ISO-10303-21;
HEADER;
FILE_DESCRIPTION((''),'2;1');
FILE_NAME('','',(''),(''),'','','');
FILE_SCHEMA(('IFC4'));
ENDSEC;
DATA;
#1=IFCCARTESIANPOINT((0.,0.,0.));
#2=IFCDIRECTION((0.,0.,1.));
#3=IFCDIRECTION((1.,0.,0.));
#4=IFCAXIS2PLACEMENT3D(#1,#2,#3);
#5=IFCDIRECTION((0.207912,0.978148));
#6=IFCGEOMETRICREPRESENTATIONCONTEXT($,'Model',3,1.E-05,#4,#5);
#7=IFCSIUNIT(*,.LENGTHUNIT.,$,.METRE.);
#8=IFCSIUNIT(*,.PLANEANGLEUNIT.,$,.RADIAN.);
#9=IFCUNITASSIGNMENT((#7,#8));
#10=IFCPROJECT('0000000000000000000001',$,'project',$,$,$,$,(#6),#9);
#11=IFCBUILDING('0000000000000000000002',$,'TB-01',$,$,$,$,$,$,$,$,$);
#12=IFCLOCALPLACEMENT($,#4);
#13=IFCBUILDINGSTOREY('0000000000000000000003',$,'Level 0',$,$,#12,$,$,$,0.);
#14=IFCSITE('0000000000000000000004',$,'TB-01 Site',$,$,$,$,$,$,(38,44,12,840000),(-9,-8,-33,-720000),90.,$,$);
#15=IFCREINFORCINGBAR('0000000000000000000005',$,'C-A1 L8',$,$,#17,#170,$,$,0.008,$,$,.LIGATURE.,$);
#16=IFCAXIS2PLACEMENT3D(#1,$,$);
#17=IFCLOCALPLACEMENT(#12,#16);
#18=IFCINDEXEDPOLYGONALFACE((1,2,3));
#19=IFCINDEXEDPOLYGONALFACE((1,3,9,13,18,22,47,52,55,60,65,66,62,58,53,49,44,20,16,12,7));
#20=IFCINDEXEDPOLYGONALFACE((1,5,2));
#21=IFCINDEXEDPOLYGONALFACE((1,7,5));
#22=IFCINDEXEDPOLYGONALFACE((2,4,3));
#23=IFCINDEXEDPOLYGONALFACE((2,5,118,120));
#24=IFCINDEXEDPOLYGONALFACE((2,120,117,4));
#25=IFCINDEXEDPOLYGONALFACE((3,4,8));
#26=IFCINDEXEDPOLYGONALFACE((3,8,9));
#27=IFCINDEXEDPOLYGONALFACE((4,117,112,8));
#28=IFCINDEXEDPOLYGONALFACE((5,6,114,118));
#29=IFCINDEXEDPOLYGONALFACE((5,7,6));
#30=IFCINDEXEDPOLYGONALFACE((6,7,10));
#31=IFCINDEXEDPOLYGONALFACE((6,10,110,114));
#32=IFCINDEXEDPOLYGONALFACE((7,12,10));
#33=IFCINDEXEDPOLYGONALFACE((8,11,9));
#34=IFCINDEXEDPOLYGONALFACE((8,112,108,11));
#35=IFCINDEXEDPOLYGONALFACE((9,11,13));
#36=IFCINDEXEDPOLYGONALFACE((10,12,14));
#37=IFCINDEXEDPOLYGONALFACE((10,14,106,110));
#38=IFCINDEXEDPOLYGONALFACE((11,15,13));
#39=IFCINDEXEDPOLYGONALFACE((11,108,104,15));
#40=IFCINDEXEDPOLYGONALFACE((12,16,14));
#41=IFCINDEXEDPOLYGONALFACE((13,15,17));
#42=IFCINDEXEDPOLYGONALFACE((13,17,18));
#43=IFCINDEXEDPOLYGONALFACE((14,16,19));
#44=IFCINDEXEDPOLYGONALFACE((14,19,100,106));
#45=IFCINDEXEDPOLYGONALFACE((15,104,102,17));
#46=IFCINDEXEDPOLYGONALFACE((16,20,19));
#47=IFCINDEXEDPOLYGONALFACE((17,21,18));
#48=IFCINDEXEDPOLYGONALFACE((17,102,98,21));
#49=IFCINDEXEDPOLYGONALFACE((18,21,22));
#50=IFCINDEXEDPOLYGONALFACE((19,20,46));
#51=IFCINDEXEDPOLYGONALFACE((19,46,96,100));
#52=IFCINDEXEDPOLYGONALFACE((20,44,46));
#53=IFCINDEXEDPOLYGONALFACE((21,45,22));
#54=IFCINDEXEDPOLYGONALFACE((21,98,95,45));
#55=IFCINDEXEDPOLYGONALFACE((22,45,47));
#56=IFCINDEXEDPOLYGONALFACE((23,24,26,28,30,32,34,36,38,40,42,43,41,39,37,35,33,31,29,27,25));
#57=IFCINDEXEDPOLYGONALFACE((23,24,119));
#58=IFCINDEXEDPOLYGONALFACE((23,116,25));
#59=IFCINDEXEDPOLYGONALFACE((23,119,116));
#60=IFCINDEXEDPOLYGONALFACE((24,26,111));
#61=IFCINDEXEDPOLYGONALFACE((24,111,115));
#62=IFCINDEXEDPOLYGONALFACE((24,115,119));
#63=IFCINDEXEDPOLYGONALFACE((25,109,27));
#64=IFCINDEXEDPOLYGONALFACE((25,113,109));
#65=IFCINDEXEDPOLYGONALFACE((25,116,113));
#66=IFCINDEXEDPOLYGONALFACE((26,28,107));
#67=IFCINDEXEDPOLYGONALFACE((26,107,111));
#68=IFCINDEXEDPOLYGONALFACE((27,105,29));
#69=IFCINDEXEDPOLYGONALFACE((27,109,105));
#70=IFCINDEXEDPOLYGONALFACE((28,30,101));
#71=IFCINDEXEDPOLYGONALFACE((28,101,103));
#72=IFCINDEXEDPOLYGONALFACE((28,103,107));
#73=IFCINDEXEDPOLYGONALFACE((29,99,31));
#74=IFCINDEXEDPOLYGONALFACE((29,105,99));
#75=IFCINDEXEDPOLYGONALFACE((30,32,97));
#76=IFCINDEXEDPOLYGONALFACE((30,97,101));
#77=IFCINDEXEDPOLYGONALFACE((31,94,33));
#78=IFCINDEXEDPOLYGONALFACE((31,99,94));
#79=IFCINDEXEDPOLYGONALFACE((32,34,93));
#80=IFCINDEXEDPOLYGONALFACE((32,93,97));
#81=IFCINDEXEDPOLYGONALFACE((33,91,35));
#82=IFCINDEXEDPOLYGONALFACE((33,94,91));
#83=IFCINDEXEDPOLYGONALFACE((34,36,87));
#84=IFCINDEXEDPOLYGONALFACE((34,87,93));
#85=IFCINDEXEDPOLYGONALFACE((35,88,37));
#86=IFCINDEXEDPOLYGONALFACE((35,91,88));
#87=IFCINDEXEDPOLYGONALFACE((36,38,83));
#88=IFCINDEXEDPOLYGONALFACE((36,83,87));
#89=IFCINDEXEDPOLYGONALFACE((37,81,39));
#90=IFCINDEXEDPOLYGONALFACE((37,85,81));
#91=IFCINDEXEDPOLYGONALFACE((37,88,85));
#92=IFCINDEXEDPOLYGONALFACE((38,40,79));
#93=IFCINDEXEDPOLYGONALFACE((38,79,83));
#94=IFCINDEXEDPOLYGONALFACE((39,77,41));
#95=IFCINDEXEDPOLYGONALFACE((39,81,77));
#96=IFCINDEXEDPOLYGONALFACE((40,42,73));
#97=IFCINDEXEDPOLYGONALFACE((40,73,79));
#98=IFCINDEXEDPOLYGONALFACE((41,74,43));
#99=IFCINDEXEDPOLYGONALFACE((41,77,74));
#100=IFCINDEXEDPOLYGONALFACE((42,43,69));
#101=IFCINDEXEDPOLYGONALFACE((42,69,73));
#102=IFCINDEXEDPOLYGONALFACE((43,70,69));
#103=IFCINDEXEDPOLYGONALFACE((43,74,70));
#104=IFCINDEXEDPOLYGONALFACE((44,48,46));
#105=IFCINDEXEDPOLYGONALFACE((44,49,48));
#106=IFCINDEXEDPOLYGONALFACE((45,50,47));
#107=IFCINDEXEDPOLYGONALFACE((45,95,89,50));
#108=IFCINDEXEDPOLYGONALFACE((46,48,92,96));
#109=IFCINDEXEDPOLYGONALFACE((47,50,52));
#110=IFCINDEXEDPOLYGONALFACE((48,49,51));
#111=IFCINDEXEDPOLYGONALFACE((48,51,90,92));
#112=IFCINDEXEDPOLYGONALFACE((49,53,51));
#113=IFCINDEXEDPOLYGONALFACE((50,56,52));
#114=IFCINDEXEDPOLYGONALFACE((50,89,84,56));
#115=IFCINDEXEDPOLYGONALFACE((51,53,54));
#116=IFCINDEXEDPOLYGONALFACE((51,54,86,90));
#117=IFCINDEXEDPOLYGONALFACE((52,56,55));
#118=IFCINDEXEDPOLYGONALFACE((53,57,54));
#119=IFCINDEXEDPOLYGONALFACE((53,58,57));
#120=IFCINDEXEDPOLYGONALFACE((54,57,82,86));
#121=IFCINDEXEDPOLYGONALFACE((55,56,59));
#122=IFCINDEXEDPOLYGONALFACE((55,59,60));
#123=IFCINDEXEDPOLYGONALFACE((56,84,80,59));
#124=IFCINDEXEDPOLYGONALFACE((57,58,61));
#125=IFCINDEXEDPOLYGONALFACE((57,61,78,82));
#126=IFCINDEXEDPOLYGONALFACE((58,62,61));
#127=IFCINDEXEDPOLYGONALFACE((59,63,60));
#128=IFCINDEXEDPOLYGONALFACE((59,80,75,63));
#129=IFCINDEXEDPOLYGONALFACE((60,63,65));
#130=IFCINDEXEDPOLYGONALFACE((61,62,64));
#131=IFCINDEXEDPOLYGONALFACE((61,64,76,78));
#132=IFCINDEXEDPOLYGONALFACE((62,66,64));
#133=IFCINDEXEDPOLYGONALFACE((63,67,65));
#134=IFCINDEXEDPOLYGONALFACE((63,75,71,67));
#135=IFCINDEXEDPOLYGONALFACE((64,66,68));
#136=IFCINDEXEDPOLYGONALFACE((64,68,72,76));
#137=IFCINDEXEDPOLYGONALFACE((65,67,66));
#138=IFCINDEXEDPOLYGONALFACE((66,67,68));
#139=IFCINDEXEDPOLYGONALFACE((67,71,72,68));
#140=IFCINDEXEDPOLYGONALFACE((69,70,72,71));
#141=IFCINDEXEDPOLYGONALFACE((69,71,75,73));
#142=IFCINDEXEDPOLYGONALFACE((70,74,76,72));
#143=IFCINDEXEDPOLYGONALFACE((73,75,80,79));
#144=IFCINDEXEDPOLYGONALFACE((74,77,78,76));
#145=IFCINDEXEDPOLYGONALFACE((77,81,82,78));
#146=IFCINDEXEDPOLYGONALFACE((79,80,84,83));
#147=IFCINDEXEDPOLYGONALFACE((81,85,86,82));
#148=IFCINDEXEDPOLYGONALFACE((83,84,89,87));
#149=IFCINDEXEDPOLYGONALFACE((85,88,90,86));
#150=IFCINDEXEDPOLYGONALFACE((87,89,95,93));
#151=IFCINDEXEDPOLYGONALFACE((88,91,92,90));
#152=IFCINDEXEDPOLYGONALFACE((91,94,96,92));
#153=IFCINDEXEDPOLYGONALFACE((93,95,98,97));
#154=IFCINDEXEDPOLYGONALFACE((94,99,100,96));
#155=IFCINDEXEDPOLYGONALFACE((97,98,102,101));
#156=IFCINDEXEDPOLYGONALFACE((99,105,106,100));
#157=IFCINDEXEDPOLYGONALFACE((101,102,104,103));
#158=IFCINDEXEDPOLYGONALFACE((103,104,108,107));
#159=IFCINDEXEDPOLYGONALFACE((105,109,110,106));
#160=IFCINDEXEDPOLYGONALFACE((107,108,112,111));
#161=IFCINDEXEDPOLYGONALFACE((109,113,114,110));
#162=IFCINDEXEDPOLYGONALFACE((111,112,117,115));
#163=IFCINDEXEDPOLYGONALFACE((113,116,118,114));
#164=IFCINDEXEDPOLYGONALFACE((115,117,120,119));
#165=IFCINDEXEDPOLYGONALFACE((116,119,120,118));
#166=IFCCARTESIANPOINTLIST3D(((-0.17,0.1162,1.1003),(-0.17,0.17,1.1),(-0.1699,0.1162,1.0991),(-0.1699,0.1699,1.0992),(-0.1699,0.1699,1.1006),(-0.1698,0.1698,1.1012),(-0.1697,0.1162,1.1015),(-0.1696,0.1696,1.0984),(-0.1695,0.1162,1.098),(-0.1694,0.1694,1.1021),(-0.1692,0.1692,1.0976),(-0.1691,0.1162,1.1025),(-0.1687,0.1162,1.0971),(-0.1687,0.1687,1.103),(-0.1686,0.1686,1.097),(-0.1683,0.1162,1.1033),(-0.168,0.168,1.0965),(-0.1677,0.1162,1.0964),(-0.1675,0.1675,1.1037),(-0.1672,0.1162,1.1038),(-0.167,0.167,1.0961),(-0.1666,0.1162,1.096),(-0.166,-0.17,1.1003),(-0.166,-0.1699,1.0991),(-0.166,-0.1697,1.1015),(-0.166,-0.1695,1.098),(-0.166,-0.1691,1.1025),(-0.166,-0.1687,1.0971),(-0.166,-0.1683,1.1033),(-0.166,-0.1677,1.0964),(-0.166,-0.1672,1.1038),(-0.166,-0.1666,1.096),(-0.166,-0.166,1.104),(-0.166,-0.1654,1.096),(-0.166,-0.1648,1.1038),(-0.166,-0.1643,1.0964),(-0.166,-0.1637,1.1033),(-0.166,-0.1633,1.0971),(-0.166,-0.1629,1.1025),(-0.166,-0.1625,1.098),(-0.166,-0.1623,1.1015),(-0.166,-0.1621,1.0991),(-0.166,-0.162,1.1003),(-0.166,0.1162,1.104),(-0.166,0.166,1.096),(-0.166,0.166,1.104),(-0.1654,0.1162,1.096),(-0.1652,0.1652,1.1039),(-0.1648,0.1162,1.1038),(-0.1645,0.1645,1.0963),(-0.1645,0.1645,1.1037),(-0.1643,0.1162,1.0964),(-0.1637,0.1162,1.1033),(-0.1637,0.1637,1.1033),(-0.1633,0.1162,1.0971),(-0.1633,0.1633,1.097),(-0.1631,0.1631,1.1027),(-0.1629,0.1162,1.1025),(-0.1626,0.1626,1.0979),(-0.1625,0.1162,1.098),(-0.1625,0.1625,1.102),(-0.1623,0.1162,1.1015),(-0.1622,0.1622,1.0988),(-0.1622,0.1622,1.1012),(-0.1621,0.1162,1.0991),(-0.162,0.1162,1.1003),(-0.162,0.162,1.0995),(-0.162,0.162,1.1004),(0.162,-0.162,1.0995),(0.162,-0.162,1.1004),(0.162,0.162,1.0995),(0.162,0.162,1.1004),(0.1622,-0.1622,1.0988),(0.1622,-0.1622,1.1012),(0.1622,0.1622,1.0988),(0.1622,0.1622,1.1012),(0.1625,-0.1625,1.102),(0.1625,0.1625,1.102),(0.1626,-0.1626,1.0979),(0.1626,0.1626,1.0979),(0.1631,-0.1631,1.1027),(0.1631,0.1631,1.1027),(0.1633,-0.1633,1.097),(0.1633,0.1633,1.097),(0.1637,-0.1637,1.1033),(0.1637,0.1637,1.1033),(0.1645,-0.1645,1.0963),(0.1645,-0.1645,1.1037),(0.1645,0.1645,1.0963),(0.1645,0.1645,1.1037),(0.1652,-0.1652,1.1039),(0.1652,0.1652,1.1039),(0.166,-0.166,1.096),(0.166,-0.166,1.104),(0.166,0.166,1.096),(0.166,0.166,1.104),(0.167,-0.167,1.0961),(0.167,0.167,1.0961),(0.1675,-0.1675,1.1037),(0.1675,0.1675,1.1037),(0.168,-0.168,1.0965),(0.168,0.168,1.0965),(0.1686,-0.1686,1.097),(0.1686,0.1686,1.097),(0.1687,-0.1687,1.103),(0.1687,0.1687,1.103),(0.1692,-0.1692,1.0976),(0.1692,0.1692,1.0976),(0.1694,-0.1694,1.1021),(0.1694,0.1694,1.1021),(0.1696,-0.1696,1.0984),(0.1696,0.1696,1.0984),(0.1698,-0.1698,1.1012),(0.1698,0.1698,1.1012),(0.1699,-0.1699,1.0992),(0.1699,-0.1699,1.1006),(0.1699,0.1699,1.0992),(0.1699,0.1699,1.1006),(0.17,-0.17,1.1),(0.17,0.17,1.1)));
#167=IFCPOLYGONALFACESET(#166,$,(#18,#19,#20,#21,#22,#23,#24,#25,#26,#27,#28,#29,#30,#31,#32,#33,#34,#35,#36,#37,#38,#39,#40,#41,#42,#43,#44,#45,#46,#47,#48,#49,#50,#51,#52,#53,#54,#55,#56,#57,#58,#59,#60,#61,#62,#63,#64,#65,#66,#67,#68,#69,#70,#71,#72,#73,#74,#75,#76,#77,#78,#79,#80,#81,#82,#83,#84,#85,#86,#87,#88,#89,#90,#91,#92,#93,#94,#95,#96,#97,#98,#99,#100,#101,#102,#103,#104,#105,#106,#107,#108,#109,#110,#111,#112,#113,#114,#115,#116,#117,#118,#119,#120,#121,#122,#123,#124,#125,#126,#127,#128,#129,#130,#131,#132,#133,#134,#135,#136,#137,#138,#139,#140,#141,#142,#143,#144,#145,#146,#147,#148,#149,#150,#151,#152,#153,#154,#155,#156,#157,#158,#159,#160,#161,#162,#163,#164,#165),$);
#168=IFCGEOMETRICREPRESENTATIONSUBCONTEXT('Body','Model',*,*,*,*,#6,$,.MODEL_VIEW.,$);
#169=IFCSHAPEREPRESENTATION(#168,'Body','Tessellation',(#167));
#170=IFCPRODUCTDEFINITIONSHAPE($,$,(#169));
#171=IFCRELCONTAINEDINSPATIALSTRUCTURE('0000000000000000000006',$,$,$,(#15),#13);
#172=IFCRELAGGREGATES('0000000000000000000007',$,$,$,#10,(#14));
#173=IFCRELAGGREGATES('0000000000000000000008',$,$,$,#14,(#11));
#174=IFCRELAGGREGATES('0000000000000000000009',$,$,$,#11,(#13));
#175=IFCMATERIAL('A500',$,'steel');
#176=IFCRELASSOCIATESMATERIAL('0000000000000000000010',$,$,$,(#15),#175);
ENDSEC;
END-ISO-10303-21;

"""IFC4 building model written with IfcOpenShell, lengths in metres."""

from ifc_helpers import new_model, entity, si_unit, direction, origin_with_axes, place, context, subcontext, project, spatial, material, element, save


model = new_model("IFC4")

# Units and contexts
model_context = context("Model", 3, precision=1e-05, world=origin_with_axes(), true_north=direction((0.207912, 0.978148)))
body_context = subcontext(model_context, "Body", "Model", "MODEL_VIEW")
ifc_project = project(units=[si_unit("LENGTHUNIT", "METRE"), si_unit("PLANEANGLEUNIT", "RADIAN")], contexts=[model_context])

# Site, building, storey
site = spatial("IfcSite", under=ifc_project, Name="TB-01 Site", RefLatitude=(38, 44, 12, 840000), RefLongitude=(-9, -8, -33, -720000), RefElevation=90.0)
building = spatial("IfcBuilding", under=site, Name="TB-01")
storey_placement = place(None, origin_with_axes())
storey = spatial("IfcBuildingStorey", under=building, at=storey_placement, Name="Level 0", Elevation=0.0)

# Reinforcing bar
ifc_material_1 = material(Name="A500", Category="steel")
reinforcing_bar_1_placement = place(storey_placement, origin_with_axes())
element("IfcReinforcingBar", 1, at=reinforcing_bar_1_placement, inside=storey, material=ifc_material_1, Name="C-A1 L8", NominalDiameter=0.008, PredefinedType="LIGATURE", context=body_context, shape_type="AdvancedSweptSolid", body=[
    entity("IfcSweptDiskSolid", entity("IfcPolyline", [entity("IfcCartesianPoint", [-0.166, -0.166, 1.1]), entity("IfcCartesianPoint", [0.166, -0.166, 1.1]), entity("IfcCartesianPoint", [0.166, 0.166, 1.1]), entity("IfcCartesianPoint", [-0.166, 0.166, 1.1]), entity("IfcCartesianPoint", [-0.166, 0.1162, 1.1])]), 0.004),
])

save(model, "model.ifc")
